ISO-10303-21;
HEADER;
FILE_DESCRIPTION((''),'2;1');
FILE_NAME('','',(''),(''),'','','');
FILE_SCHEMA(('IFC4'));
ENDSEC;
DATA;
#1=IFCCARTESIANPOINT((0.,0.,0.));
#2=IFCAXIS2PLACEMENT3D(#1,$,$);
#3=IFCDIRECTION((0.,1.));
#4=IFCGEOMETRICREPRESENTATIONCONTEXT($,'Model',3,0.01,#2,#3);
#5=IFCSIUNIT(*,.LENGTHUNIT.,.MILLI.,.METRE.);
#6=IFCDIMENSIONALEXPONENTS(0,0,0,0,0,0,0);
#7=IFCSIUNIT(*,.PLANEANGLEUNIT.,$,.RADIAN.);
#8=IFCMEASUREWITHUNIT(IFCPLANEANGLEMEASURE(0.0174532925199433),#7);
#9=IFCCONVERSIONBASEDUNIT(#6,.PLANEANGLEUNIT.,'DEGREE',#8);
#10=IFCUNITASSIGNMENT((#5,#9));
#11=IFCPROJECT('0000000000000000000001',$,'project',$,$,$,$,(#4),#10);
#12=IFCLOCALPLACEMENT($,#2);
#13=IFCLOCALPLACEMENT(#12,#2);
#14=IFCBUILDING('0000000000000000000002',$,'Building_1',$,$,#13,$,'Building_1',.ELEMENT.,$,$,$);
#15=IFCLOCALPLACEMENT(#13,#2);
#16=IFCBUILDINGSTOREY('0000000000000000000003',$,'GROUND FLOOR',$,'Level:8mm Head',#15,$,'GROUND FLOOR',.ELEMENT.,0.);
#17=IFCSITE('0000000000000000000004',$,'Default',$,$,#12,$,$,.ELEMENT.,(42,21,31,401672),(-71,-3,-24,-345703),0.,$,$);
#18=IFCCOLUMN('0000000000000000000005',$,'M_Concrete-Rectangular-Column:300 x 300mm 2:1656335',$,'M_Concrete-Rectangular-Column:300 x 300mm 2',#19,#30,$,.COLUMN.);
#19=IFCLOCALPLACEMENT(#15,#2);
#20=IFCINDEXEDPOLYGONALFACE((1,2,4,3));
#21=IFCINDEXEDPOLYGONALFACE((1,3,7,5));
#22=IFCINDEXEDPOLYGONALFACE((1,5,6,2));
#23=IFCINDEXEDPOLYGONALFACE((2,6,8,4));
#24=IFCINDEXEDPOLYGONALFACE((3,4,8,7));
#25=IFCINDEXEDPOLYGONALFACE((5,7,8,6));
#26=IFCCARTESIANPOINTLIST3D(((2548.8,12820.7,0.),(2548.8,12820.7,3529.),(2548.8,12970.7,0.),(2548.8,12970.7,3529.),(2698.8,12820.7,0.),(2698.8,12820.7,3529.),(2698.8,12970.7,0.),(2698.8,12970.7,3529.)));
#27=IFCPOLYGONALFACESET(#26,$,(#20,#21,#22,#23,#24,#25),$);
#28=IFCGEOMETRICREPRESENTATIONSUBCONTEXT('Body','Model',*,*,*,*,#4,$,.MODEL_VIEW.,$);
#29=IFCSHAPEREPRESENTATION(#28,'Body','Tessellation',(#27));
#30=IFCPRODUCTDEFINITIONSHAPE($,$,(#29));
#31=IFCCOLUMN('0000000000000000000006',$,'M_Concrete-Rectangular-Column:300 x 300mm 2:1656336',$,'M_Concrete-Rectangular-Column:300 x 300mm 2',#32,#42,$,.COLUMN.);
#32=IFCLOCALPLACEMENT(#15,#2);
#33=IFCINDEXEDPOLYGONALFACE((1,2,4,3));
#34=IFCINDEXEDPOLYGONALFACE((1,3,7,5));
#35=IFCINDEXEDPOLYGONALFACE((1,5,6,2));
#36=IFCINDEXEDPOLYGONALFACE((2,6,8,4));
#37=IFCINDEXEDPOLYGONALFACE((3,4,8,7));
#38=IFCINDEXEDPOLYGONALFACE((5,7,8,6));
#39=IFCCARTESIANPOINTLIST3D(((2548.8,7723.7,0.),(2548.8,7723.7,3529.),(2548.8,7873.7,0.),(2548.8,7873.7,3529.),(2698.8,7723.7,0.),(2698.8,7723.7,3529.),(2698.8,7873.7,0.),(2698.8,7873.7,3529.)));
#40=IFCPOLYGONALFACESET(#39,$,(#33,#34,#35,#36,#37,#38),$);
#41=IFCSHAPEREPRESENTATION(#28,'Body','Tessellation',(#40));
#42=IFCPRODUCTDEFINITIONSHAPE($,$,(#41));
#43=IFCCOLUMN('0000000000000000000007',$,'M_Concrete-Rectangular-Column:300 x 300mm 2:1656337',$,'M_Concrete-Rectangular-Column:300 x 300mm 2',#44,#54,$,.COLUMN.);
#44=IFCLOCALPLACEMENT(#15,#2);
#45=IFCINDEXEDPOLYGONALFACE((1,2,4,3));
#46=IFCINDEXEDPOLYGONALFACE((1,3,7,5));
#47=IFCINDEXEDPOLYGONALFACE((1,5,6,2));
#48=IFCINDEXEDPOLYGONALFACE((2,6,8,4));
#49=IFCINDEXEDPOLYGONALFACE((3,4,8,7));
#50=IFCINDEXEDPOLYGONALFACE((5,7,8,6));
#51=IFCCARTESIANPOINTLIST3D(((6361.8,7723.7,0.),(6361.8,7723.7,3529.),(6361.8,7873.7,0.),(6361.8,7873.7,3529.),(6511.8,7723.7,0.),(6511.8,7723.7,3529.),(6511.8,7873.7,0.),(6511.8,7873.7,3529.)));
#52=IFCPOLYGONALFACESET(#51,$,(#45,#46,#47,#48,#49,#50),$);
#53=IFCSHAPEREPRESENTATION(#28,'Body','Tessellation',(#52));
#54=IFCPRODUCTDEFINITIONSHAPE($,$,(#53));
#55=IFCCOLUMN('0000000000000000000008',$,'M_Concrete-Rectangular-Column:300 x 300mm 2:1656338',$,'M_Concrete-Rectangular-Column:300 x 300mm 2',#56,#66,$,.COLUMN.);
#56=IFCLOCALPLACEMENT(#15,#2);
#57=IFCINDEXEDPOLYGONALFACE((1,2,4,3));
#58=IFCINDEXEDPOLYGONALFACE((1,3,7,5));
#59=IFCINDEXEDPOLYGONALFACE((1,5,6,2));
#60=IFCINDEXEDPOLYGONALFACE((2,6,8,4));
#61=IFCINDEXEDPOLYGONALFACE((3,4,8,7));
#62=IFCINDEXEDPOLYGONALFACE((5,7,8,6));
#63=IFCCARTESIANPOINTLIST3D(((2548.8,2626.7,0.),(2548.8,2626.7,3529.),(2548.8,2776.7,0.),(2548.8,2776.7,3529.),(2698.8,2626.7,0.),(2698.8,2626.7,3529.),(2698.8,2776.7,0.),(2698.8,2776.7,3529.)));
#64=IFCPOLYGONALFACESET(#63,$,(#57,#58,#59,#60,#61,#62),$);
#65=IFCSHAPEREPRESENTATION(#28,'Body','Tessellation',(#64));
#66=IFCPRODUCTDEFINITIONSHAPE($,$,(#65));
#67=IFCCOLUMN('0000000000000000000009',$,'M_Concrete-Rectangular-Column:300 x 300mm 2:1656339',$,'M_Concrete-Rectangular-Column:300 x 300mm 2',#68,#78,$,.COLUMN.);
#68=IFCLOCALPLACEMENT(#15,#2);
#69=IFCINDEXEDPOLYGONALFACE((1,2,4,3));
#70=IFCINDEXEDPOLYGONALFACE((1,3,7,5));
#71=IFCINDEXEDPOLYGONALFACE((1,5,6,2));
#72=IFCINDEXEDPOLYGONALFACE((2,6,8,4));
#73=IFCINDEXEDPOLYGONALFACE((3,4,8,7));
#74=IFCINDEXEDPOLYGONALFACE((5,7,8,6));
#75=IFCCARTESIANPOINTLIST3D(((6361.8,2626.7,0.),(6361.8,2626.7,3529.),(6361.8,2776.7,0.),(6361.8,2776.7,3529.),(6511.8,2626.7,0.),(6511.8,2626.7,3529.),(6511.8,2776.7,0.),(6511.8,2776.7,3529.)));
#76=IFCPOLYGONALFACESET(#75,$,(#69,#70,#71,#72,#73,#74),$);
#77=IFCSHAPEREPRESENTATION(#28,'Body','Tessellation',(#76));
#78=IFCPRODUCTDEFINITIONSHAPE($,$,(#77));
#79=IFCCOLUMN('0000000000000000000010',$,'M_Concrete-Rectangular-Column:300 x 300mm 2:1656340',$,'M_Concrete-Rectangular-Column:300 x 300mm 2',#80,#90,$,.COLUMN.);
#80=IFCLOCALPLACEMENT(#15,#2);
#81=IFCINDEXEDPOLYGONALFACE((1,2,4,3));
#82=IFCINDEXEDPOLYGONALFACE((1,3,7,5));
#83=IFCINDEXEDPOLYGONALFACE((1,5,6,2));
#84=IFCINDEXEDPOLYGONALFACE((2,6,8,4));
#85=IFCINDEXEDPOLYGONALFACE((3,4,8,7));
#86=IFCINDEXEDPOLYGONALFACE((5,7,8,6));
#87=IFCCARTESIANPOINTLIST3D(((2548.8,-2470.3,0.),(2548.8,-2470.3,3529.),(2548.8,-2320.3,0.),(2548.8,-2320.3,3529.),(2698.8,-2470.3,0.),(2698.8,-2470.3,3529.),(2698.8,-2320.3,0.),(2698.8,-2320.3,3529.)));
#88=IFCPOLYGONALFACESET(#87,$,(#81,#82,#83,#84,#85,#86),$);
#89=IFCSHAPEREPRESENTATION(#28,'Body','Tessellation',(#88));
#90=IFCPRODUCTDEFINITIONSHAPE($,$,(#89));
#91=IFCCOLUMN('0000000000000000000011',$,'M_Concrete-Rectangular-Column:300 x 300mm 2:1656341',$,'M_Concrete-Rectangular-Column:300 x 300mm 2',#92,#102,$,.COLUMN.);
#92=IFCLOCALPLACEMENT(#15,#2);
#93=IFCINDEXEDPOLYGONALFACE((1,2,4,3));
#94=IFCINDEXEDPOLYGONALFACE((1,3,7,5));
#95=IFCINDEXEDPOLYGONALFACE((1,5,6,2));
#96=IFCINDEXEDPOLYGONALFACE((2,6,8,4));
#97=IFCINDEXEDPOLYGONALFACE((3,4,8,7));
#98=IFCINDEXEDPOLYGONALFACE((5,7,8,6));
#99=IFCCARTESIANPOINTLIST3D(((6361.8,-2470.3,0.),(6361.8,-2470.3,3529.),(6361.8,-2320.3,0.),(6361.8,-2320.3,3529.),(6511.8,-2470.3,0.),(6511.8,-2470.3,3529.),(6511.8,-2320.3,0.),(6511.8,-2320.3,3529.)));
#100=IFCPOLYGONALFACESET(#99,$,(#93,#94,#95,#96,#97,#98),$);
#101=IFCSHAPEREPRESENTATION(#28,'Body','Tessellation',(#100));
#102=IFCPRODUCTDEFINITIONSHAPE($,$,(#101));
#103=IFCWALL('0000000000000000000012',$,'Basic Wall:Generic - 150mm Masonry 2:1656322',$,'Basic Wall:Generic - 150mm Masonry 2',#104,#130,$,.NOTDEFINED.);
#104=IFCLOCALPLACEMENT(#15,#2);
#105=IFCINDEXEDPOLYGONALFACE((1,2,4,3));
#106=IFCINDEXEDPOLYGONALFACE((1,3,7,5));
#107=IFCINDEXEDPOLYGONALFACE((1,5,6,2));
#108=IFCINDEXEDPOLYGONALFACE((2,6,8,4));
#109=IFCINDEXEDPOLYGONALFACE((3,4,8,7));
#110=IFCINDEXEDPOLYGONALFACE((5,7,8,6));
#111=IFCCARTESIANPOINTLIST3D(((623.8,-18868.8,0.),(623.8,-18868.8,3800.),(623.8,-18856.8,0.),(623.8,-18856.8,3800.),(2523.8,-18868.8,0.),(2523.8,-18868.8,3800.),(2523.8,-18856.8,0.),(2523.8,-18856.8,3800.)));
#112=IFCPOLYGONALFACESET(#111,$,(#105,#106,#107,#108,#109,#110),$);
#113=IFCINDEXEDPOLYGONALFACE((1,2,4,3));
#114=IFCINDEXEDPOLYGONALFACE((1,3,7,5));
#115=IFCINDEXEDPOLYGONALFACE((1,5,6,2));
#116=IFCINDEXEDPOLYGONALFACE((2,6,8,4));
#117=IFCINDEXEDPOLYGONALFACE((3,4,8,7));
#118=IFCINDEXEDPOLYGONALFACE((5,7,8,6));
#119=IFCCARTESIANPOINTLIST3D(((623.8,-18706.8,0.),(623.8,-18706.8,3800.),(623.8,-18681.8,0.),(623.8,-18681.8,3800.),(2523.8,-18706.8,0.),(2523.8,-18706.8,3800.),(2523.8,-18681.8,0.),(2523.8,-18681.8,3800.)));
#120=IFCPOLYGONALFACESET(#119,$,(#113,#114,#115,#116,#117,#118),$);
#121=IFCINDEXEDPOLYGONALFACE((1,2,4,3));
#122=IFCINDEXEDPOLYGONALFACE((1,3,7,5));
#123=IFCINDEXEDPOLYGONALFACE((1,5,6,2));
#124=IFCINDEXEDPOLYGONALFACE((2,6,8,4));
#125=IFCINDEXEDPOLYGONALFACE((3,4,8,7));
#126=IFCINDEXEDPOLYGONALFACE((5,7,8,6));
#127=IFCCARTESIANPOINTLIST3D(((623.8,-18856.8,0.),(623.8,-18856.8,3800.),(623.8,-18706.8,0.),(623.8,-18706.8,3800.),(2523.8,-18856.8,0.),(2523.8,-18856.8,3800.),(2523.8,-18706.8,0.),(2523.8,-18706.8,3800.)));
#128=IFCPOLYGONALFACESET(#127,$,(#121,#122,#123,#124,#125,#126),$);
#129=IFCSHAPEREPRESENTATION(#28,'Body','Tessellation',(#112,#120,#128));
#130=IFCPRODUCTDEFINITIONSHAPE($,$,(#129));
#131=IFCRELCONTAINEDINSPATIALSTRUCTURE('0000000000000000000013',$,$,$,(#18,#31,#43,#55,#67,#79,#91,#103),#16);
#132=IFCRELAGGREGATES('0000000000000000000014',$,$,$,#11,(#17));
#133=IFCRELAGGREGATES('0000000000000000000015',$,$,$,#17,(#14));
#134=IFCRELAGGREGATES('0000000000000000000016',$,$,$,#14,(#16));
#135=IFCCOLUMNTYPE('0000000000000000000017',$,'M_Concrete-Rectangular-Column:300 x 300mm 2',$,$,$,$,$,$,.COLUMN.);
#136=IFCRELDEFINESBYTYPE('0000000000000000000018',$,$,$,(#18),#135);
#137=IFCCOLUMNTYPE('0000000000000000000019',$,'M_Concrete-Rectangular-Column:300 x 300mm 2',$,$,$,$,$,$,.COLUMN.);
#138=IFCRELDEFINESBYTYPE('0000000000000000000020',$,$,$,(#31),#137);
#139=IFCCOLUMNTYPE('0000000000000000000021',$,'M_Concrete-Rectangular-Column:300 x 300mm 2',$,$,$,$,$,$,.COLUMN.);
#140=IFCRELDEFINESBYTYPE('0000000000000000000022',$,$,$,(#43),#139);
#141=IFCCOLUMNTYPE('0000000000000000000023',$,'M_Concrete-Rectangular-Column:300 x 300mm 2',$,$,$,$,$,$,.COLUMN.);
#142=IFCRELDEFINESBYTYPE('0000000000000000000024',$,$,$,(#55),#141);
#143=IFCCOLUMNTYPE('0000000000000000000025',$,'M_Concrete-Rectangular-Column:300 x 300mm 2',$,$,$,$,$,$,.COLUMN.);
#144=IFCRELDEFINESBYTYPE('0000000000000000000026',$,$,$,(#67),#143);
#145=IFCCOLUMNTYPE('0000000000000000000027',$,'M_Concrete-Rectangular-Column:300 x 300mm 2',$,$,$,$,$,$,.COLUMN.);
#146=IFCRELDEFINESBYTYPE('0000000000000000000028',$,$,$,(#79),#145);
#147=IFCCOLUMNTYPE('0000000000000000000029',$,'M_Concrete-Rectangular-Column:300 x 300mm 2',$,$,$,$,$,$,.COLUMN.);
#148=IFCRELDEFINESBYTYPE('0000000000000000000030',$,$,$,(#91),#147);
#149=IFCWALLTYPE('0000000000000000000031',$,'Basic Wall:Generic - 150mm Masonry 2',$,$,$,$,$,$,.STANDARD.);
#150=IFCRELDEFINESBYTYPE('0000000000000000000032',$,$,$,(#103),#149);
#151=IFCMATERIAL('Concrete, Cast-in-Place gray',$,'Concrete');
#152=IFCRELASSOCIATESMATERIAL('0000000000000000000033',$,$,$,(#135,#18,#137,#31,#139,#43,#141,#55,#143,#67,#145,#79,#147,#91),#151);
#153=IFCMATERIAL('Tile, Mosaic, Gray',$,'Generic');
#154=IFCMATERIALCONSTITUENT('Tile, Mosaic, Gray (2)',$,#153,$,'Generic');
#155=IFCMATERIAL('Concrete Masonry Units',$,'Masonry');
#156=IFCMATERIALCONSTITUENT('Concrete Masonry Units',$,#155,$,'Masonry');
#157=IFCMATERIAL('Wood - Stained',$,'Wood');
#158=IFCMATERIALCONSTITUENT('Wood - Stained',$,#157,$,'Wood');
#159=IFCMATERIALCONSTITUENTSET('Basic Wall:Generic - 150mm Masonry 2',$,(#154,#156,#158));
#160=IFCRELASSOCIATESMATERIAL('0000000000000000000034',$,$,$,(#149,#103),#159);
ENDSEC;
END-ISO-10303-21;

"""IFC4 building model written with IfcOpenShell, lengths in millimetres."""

from ifc_helpers import new_model, entity, si_unit, converted_unit, direction, frame, origin, place, context, subcontext, project, spatial, indexed_curve, outline, extrude, source, transform, mapped, material, constituent, constituent_set, type_object, type_shapes, element, save


model = new_model("IFC4")

# Units and contexts
model_context = context("Model", 3, precision=0.01, world=origin(), true_north=direction((0.0, 1.0)))
body_context = subcontext(model_context, "Body", "Model", "MODEL_VIEW")
ifc_project = project(units=[si_unit("LENGTHUNIT", "METRE", prefix="MILLI"), converted_unit("PLANEANGLEUNIT", "DEGREE", entity("IfcPlaneAngleMeasure", 0.0174532925199433), si_unit("PLANEANGLEUNIT", "RADIAN"), dimensions=[0, 0, 0, 0, 0, 0, 0])], contexts=[model_context])

# Site, building, storey
site_placement = place(None, origin())
site = spatial("IfcSite", under=ifc_project, at=site_placement, Name="Default", CompositionType="ELEMENT", RefLatitude=(42, 21, 31, 401672), RefLongitude=(-71, -3, -24, -345703), RefElevation=0.0)
building_placement = place(site_placement, origin())
building = spatial("IfcBuilding", under=site, at=building_placement, Name="Building_1", LongName="Building_1", CompositionType="ELEMENT")
storey_placement = place(building_placement, origin())
storey = spatial("IfcBuildingStorey", under=building, at=storey_placement, Name="GROUND FLOOR", ObjectType="Level:8mm Head", LongName="GROUND FLOOR", CompositionType="ELEMENT", Elevation=0.0)

# Columns
ifc_material_1 = material(Name="Concrete, Cast-in-Place gray", Category="Concrete")
column_type_1 = type_object("IfcColumnType", Name="M_Concrete-Rectangular-Column:300 x 300mm 2", PredefinedType="COLUMN", material=ifc_material_1)
shared_shape_1 = source(origin(), body_context, "Body", "SweptSolid", [
    extrude(outline(indexed_curve([(-75.0, -75.0), (75.0, -75.0), (75.0, 75.0), (-75.0, 75.0), (-75.0, -75.0)], self_intersect=False)), frame((2623.8, 12895.7, 0.0)), (0.0, 0.0, 1.0), 3529.0),
])
type_shapes(column_type_1, [shared_shape_1])
column_1_placement = place(storey_placement, origin())
element("IfcColumn", 1, at=column_1_placement, inside=storey, type_object=column_type_1, material=ifc_material_1, Name="M_Concrete-Rectangular-Column:300 x 300mm 2:1656335", ObjectType="M_Concrete-Rectangular-Column:300 x 300mm 2", PredefinedType="COLUMN", context=body_context, shape_type="MappedRepresentation", body=[
    mapped(shared_shape_1, transform((0.0, 0.0, 0.0), scale=1.0)),
])
column_type_2 = type_object("IfcColumnType", Name="M_Concrete-Rectangular-Column:300 x 300mm 2", PredefinedType="COLUMN", material=ifc_material_1)
shared_shape_2 = source(origin(), body_context, "Body", "SweptSolid", [
    extrude(outline(indexed_curve([(-75.0, -75.0), (75.0, -75.0), (75.0, 75.0), (-75.0, 75.0), (-75.0, -75.0)], self_intersect=False)), frame((2623.8, 7798.7, 0.0)), (0.0, 0.0, 1.0), 3529.0),
])
type_shapes(column_type_2, [shared_shape_2])
column_2_placement = place(storey_placement, origin())
element("IfcColumn", 2, at=column_2_placement, inside=storey, type_object=column_type_2, material=ifc_material_1, Name="M_Concrete-Rectangular-Column:300 x 300mm 2:1656336", ObjectType="M_Concrete-Rectangular-Column:300 x 300mm 2", PredefinedType="COLUMN", context=body_context, shape_type="MappedRepresentation", body=[
    mapped(shared_shape_2, transform((0.0, 0.0, 0.0), scale=1.0)),
])
column_type_3 = type_object("IfcColumnType", Name="M_Concrete-Rectangular-Column:300 x 300mm 2", PredefinedType="COLUMN", material=ifc_material_1)
shared_shape_3 = source(origin(), body_context, "Body", "SweptSolid", [
    extrude(outline(indexed_curve([(-75.0, -75.0), (75.0, -75.0), (75.0, 75.0), (-75.0, 75.0), (-75.0, -75.0)], self_intersect=False)), frame((6436.8, 7798.7, 0.0)), (0.0, 0.0, 1.0), 3529.0),
])
type_shapes(column_type_3, [shared_shape_3])
column_3_placement = place(storey_placement, origin())
element("IfcColumn", 3, at=column_3_placement, inside=storey, type_object=column_type_3, material=ifc_material_1, Name="M_Concrete-Rectangular-Column:300 x 300mm 2:1656337", ObjectType="M_Concrete-Rectangular-Column:300 x 300mm 2", PredefinedType="COLUMN", context=body_context, shape_type="MappedRepresentation", body=[
    mapped(shared_shape_3, transform((0.0, 0.0, 0.0), scale=1.0)),
])
column_type_4 = type_object("IfcColumnType", Name="M_Concrete-Rectangular-Column:300 x 300mm 2", PredefinedType="COLUMN", material=ifc_material_1)
shared_shape_4 = source(origin(), body_context, "Body", "SweptSolid", [
    extrude(outline(indexed_curve([(-75.0, -75.0), (75.0, -75.0), (75.0, 75.0), (-75.0, 75.0), (-75.0, -75.0)], self_intersect=False)), frame((2623.8, 2701.7, 0.0)), (0.0, 0.0, 1.0), 3529.0),
])
type_shapes(column_type_4, [shared_shape_4])
column_4_placement = place(storey_placement, origin())
element("IfcColumn", 4, at=column_4_placement, inside=storey, type_object=column_type_4, material=ifc_material_1, Name="M_Concrete-Rectangular-Column:300 x 300mm 2:1656338", ObjectType="M_Concrete-Rectangular-Column:300 x 300mm 2", PredefinedType="COLUMN", context=body_context, shape_type="MappedRepresentation", body=[
    mapped(shared_shape_4, transform((0.0, 0.0, 0.0), scale=1.0)),
])
column_type_5 = type_object("IfcColumnType", Name="M_Concrete-Rectangular-Column:300 x 300mm 2", PredefinedType="COLUMN", material=ifc_material_1)
shared_shape_5 = source(origin(), body_context, "Body", "SweptSolid", [
    extrude(outline(indexed_curve([(-75.0, -75.0), (75.0, -75.0), (75.0, 75.0), (-75.0, 75.0), (-75.0, -75.0)], self_intersect=False)), frame((6436.8, 2701.7, 0.0)), (0.0, 0.0, 1.0), 3529.0),
])
type_shapes(column_type_5, [shared_shape_5])
column_5_placement = place(storey_placement, origin())
element("IfcColumn", 5, at=column_5_placement, inside=storey, type_object=column_type_5, material=ifc_material_1, Name="M_Concrete-Rectangular-Column:300 x 300mm 2:1656339", ObjectType="M_Concrete-Rectangular-Column:300 x 300mm 2", PredefinedType="COLUMN", context=body_context, shape_type="MappedRepresentation", body=[
    mapped(shared_shape_5, transform((0.0, 0.0, 0.0), scale=1.0)),
])
column_type_6 = type_object("IfcColumnType", Name="M_Concrete-Rectangular-Column:300 x 300mm 2", PredefinedType="COLUMN", material=ifc_material_1)
shared_shape_6 = source(origin(), body_context, "Body", "SweptSolid", [
    extrude(outline(indexed_curve([(-75.0, -75.0), (75.0, -75.0), (75.0, 75.0), (-75.0, 75.0), (-75.0, -75.0)], self_intersect=False)), frame((2623.8, -2395.3, 0.0)), (0.0, 0.0, 1.0), 3529.0),
])
type_shapes(column_type_6, [shared_shape_6])
column_6_placement = place(storey_placement, origin())
element("IfcColumn", 6, at=column_6_placement, inside=storey, type_object=column_type_6, material=ifc_material_1, Name="M_Concrete-Rectangular-Column:300 x 300mm 2:1656340", ObjectType="M_Concrete-Rectangular-Column:300 x 300mm 2", PredefinedType="COLUMN", context=body_context, shape_type="MappedRepresentation", body=[
    mapped(shared_shape_6, transform((0.0, 0.0, 0.0), scale=1.0)),
])
column_type_7 = type_object("IfcColumnType", Name="M_Concrete-Rectangular-Column:300 x 300mm 2", PredefinedType="COLUMN", material=ifc_material_1)
shared_shape_7 = source(origin(), body_context, "Body", "SweptSolid", [
    extrude(outline(indexed_curve([(-75.0, -75.0), (75.0, -75.0), (75.0, 75.0), (-75.0, 75.0), (-75.0, -75.0)], self_intersect=False)), frame((6436.8, -2395.3, 0.0)), (0.0, 0.0, 1.0), 3529.0),
])
type_shapes(column_type_7, [shared_shape_7])
column_7_placement = place(storey_placement, origin())
element("IfcColumn", 7, at=column_7_placement, inside=storey, type_object=column_type_7, material=ifc_material_1, Name="M_Concrete-Rectangular-Column:300 x 300mm 2:1656341", ObjectType="M_Concrete-Rectangular-Column:300 x 300mm 2", PredefinedType="COLUMN", context=body_context, shape_type="MappedRepresentation", body=[
    mapped(shared_shape_7, transform((0.0, 0.0, 0.0), scale=1.0)),
])

# Wall
ifc_material_2 = material(Name="Tile, Mosaic, Gray", Category="Generic")
ifc_constituent_1 = constituent(ifc_material_2, Name="Tile, Mosaic, Gray (2)", Category="Generic")
ifc_material_3 = material(Name="Concrete Masonry Units", Category="Masonry")
ifc_constituent_2 = constituent(ifc_material_3, Name="Concrete Masonry Units", Category="Masonry")
ifc_material_4 = material(Name="Wood - Stained", Category="Wood")
ifc_constituent_3 = constituent(ifc_material_4, Name="Wood - Stained", Category="Wood")
ifc_constituent_set_1 = constituent_set(constituents=[ifc_constituent_1, ifc_constituent_2, ifc_constituent_3], Name="Basic Wall:Generic - 150mm Masonry 2")
wall_type_1 = type_object("IfcWallType", Name="Basic Wall:Generic - 150mm Masonry 2", PredefinedType="STANDARD", material=ifc_constituent_set_1)
wall_1_placement = place(storey_placement, frame((2523.8, -18775.3, 0.0), z_axis=(0.0, 0.0, 1.0), x_axis=(-1.0, 0.0, 0.0)))
element("IfcWall", 8, at=wall_1_placement, inside=storey, type_object=wall_type_1, material=ifc_constituent_set_1, Name="Basic Wall:Generic - 150mm Masonry 2:1656322", ObjectType="Basic Wall:Generic - 150mm Masonry 2", PredefinedType="NOTDEFINED", context=body_context, shape_type="SweptSolid", body=[
    extrude(outline(indexed_curve([(-6.0, -950.0), (6.0, -950.0), (6.0, 950.0), (-6.0, 950.0), (-6.0, -950.0)], self_intersect=False)), frame((950.0, 87.5, 0.0), z_axis=(0.0, 0.0, 1.0), x_axis=(0.0, -1.0, 0.0)), (0.0, 0.0, 1.0), 3800.0),
    extrude(outline(indexed_curve([(-12.5, -950.0), (12.5, -950.0), (12.5, 950.0), (-12.5, 950.0), (-12.5, -950.0)], self_intersect=False)), frame((950.0, -81.0, 0.0), z_axis=(0.0, 0.0, 1.0), x_axis=(0.0, 1.0, 0.0)), (0.0, 0.0, 1.0), 3800.0),
    extrude(outline(indexed_curve([(-950.0, -75.0), (950.0, -75.0), (950.0, 75.0), (-950.0, 75.0), (-950.0, -75.0)], self_intersect=False)), frame((950.0, 6.5, 0.0)), (0.0, 0.0, 1.0), 3800.0),
])

save(model, "model.ifc")
